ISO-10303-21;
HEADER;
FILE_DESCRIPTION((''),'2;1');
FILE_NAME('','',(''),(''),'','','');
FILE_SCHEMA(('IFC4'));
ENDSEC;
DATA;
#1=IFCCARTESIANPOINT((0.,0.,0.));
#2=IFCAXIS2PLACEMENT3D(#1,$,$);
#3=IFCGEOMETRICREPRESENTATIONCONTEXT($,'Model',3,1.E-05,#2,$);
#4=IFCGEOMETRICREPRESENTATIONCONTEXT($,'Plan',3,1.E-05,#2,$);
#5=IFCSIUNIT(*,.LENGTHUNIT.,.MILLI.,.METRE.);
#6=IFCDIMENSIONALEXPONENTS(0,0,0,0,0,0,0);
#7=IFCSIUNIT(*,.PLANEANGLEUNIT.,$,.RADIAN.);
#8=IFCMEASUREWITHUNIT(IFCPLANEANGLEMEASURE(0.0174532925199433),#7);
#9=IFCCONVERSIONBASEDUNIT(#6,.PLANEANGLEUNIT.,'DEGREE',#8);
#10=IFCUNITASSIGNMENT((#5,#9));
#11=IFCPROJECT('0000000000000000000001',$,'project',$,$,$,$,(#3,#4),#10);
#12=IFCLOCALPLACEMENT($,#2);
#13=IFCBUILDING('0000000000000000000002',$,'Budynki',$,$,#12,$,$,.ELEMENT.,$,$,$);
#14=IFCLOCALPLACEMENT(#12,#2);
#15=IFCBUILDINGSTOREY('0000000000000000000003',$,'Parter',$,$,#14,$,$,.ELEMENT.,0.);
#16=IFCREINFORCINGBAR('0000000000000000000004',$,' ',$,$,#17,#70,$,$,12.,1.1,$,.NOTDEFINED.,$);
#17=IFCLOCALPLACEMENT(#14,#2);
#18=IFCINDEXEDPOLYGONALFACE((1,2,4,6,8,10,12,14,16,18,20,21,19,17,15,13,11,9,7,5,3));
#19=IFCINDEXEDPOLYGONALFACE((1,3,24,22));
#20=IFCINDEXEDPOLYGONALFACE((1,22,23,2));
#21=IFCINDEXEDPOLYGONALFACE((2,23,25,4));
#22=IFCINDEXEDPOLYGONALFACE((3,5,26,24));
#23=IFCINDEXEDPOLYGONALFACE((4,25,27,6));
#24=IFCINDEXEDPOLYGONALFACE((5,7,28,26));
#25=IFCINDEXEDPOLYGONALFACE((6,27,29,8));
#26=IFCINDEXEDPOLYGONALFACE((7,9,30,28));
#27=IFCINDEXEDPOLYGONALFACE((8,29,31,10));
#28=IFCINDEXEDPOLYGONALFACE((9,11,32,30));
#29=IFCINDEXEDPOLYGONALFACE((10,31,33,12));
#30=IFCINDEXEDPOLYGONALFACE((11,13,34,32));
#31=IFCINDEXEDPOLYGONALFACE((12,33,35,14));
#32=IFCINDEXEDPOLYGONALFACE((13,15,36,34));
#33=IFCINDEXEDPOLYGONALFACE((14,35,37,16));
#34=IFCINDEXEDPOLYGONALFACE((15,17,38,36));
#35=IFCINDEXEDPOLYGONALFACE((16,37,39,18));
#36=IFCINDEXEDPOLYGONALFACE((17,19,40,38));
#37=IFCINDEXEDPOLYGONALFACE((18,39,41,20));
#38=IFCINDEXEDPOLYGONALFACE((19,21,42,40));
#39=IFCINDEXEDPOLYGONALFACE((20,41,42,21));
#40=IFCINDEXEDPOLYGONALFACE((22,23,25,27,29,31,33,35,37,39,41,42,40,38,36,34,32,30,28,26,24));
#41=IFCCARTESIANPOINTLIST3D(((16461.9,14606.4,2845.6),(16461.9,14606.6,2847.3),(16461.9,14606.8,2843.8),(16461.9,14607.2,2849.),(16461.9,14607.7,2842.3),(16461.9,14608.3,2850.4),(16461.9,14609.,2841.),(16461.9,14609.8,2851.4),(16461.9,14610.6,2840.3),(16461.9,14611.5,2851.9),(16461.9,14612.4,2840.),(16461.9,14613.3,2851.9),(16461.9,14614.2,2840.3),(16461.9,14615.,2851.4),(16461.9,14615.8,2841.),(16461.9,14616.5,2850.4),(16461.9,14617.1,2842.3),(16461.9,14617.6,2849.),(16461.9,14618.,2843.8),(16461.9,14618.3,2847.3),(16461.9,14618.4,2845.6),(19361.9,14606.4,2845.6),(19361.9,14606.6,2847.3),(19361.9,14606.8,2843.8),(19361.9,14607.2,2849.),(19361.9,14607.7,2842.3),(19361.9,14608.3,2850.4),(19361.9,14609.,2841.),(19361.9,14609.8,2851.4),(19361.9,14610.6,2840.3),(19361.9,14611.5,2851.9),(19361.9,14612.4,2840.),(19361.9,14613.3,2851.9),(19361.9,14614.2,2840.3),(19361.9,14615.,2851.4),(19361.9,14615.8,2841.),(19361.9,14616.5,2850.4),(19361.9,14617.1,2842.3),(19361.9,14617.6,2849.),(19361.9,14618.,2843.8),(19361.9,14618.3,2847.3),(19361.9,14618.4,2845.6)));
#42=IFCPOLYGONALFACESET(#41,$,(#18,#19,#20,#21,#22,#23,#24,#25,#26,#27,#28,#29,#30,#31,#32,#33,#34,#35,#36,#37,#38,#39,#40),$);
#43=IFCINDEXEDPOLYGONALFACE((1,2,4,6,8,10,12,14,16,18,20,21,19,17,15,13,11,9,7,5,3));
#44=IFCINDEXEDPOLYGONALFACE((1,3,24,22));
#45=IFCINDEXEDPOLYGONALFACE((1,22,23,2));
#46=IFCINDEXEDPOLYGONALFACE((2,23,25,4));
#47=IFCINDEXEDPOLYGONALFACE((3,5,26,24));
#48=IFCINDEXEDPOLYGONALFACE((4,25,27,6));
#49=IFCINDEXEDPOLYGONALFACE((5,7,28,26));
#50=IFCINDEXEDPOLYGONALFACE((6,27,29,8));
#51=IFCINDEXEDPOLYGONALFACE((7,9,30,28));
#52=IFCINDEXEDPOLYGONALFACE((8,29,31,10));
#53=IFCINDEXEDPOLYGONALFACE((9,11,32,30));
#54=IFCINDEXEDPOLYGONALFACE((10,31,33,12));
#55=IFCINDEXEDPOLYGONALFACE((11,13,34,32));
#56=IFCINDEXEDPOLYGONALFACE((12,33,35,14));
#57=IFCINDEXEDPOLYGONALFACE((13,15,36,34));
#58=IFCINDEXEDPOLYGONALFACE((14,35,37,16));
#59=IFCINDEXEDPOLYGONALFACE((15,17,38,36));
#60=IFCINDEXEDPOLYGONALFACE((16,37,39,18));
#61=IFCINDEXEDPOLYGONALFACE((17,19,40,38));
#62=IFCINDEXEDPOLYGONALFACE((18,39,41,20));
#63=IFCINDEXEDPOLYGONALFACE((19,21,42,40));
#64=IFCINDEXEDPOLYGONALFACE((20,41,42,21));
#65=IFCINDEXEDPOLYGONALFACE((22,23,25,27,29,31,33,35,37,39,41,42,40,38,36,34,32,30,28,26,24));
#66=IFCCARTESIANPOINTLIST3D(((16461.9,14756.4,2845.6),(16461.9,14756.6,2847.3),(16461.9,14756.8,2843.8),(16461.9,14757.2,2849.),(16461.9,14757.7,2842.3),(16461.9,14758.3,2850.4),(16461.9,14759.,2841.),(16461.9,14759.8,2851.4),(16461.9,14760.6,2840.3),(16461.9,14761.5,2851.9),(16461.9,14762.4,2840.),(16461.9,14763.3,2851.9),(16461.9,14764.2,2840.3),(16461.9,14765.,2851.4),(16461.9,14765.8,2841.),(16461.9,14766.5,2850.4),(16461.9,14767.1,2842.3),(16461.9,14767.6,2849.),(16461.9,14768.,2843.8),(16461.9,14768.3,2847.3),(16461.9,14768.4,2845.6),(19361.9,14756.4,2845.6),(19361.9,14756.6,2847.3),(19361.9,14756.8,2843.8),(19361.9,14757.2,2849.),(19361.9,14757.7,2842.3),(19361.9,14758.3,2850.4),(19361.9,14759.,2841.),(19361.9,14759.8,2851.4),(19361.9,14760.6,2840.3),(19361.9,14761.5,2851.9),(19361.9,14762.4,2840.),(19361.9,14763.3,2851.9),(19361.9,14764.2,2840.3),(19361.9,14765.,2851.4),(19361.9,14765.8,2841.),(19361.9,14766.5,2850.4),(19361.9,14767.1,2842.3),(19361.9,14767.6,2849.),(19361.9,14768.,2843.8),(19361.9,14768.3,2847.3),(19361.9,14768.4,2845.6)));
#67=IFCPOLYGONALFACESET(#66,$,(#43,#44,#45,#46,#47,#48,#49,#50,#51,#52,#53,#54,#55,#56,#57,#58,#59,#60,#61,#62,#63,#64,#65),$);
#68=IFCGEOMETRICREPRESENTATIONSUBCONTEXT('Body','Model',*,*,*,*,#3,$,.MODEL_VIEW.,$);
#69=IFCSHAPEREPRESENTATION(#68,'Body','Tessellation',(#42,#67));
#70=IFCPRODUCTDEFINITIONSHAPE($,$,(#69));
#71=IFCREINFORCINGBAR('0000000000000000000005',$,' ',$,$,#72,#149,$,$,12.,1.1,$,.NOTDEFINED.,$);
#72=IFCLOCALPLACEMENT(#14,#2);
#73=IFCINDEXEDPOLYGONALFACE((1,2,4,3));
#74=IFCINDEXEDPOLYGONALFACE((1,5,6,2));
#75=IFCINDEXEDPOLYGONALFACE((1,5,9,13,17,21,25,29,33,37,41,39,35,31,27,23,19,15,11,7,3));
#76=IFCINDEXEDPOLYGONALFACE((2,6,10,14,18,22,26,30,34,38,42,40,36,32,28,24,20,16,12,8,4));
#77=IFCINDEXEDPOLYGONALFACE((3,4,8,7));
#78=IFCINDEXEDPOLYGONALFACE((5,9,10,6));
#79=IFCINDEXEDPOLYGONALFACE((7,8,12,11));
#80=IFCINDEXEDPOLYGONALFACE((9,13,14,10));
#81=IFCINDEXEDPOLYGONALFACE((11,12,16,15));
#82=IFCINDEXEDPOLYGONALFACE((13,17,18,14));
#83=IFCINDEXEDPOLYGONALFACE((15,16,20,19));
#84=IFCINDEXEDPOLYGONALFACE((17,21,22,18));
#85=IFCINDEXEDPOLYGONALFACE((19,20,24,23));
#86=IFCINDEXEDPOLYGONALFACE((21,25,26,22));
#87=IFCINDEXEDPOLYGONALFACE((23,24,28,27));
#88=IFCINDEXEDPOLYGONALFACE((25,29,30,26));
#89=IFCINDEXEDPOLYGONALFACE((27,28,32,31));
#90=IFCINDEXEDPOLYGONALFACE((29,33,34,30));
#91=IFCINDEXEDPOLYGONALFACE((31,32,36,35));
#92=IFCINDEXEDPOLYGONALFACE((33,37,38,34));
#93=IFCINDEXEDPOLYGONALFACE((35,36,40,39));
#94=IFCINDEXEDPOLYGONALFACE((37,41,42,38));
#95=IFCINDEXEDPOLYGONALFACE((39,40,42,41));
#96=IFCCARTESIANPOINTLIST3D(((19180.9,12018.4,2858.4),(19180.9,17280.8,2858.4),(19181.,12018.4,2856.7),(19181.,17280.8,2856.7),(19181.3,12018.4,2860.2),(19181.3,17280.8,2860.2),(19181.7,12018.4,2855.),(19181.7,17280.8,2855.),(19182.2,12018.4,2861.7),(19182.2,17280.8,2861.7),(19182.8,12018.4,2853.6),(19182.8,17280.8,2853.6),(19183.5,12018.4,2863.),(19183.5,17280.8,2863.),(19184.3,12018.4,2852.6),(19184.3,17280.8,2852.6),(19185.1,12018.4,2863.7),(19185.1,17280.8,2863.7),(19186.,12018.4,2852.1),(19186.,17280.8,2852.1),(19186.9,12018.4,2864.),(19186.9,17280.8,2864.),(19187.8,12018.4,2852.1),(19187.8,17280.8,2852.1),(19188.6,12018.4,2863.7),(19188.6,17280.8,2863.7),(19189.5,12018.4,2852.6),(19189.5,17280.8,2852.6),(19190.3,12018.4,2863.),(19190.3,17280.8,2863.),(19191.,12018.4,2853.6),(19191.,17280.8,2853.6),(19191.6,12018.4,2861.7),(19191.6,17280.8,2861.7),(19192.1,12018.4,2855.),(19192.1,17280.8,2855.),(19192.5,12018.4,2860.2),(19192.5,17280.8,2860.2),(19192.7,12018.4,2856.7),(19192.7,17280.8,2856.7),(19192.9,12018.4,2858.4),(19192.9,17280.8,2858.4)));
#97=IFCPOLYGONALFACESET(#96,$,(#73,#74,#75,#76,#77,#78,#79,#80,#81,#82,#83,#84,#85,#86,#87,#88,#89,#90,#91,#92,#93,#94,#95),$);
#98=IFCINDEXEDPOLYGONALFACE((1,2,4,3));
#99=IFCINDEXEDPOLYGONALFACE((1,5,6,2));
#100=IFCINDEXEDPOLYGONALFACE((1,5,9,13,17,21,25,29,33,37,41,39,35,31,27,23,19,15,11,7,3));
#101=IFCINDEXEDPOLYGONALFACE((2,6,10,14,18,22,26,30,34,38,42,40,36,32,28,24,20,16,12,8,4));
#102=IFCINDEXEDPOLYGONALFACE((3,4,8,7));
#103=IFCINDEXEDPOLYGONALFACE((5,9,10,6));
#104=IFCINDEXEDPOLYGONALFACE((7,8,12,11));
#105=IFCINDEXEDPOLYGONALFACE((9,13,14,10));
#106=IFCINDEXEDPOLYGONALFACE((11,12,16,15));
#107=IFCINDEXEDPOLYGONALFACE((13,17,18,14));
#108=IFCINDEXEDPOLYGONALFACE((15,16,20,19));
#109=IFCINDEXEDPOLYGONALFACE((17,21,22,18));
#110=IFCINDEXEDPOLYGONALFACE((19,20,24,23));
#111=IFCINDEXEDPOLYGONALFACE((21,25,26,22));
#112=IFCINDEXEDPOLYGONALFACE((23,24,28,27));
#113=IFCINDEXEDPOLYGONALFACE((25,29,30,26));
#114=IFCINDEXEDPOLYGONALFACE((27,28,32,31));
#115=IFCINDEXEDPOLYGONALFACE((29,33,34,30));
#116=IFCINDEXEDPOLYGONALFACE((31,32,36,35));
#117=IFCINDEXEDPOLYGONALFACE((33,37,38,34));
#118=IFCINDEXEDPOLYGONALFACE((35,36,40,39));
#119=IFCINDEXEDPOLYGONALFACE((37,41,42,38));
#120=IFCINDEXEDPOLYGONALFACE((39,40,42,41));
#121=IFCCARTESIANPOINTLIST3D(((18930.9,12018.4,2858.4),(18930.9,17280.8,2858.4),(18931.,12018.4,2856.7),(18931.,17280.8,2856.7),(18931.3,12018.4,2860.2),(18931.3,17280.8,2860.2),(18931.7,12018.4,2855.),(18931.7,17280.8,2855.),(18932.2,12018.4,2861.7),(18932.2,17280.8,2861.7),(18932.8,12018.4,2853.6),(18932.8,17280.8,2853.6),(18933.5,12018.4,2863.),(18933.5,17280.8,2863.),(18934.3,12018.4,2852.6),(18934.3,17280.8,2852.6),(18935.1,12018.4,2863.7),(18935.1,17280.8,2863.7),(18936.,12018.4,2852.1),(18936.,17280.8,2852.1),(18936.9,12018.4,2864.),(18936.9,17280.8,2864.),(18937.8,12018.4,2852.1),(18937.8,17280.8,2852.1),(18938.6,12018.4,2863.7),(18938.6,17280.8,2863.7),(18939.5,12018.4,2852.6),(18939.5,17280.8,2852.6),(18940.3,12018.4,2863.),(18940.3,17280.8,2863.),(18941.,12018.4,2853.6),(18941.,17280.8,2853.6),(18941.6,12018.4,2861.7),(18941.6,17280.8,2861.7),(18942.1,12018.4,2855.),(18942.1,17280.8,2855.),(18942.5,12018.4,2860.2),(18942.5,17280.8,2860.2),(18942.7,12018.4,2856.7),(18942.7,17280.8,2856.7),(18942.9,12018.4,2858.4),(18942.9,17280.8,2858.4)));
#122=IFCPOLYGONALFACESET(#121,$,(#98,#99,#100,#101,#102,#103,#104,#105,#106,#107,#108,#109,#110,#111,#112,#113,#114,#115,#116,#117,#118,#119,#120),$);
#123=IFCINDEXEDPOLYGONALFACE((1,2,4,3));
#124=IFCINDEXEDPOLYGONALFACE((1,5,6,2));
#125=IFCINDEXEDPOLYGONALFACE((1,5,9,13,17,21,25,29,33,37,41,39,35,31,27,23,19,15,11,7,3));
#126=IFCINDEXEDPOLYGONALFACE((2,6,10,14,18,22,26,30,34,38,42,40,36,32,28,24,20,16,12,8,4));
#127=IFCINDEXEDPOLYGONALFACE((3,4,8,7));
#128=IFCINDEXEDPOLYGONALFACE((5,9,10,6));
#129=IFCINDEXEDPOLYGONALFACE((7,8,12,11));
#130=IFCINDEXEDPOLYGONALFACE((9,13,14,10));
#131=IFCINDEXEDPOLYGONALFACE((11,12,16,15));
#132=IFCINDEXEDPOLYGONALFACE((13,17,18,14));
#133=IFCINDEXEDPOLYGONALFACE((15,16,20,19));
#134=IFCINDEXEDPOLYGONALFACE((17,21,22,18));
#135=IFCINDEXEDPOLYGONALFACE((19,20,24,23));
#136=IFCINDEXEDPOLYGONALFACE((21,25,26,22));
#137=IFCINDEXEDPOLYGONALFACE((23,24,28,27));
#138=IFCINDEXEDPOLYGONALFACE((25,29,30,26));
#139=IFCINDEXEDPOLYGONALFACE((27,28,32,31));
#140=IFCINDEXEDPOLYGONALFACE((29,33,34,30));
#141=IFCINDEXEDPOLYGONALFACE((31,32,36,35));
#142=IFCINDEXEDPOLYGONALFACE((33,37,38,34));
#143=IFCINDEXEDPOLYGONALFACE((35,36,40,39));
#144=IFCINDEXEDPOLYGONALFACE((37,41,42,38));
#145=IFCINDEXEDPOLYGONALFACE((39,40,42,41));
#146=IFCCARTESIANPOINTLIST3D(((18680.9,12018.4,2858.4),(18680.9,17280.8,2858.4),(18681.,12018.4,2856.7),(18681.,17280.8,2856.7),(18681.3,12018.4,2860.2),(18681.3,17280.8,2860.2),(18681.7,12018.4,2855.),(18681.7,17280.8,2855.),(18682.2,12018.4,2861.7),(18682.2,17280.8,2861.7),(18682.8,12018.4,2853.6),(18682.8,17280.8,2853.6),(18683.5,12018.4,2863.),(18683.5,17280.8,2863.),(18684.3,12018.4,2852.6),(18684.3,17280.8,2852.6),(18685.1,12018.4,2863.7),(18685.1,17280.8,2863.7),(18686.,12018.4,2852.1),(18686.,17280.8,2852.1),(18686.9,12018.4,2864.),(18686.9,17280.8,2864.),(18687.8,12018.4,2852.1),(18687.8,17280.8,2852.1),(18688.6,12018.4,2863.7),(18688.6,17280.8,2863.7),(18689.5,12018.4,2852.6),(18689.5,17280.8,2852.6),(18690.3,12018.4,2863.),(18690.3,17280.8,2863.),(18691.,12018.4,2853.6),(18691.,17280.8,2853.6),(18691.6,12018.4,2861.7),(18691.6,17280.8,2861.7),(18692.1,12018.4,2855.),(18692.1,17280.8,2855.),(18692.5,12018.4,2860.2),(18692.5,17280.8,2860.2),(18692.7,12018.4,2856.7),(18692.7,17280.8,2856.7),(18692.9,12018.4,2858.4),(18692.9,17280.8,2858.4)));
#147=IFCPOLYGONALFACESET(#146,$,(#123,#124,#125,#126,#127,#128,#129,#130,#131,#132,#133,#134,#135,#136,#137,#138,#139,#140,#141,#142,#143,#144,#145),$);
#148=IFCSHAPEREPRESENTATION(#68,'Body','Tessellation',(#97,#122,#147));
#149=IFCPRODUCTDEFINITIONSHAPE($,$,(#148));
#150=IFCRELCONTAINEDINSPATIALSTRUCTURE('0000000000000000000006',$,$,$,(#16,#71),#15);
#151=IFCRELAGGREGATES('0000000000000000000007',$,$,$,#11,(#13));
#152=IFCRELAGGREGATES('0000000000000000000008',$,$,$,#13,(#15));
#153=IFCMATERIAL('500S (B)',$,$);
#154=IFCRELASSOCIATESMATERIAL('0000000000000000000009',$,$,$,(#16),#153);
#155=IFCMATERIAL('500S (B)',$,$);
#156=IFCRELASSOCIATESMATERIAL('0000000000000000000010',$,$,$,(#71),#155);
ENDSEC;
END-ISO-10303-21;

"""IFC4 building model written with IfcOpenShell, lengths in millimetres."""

from ifc_helpers import new_model, entity, si_unit, converted_unit, frame, origin, place, context, subcontext, project, spatial, material, element, save


model = new_model("IFC4")

# Units and contexts
model_context = context("Model", 3, precision=1e-05, world=origin())
plan_context = context("Plan", 3, precision=1e-05, world=origin())
body_context = subcontext(model_context, "Body", "Model", "MODEL_VIEW")
ifc_project = project(units=[si_unit("LENGTHUNIT", "METRE", prefix="MILLI"), converted_unit("PLANEANGLEUNIT", "DEGREE", entity("IfcPlaneAngleMeasure", 0.0174532925199433), si_unit("PLANEANGLEUNIT", "RADIAN"), dimensions=[0, 0, 0, 0, 0, 0, 0])], contexts=[model_context, plan_context])

# Building, storey
building_placement = place(None, origin())
building = spatial("IfcBuilding", under=ifc_project, at=building_placement, Name="Budynki", CompositionType="ELEMENT")
storey_placement = place(building_placement, origin())
storey = spatial("IfcBuildingStorey", under=building, at=storey_placement, Name="Parter", CompositionType="ELEMENT", Elevation=0.0)

# Reinforcing bars
ifc_material_1 = material(Name="500S (B)")
reinforcing_bar_1_placement = place(storey_placement, frame((19361.9, 14612.4, 2846.0)))
element("IfcReinforcingBar", 1, at=reinforcing_bar_1_placement, inside=storey, material=ifc_material_1, Name=" ", CrossSectionArea=1.1, NominalDiameter=12.0, PredefinedType="NOTDEFINED", context=body_context, shape_type="AdvancedSweptSolid", body=[
    entity("IfcSweptDiskSolid", entity("IfcPolyline", [entity("IfcCartesianPoint", [0.0, 0.0, 0.0]), entity("IfcCartesianPoint", [-2900.0, 0.0, 0.0])]), 6.0, None, 0.0, 1.0),
    entity("IfcSweptDiskSolid", entity("IfcPolyline", [entity("IfcCartesianPoint", [0.0, 150.0, 0.0]), entity("IfcCartesianPoint", [-2900.0, 150.0, 0.0])]), 6.0, None, 0.0, 1.0),
])
ifc_material_2 = material(Name="500S (B)")
reinforcing_bar_2_placement = place(storey_placement, frame((19186.9, 12018.4, 2858.0)))
element("IfcReinforcingBar", 2, at=reinforcing_bar_2_placement, inside=storey, material=ifc_material_2, Name=" ", CrossSectionArea=1.1, NominalDiameter=12.0, PredefinedType="NOTDEFINED", context=body_context, shape_type="AdvancedSweptSolid", body=[
    entity("IfcSweptDiskSolid", entity("IfcPolyline", [entity("IfcCartesianPoint", [0.0, 0.0, 0.0]), entity("IfcCartesianPoint", [0.0, 5262.4, 0.0])]), 6.0, None, 0.0, 1.0),
    entity("IfcSweptDiskSolid", entity("IfcPolyline", [entity("IfcCartesianPoint", [-250.0, 0.0, 0.0]), entity("IfcCartesianPoint", [-250.0, 5262.4, 0.0])]), 6.0, None, 0.0, 1.0),
    entity("IfcSweptDiskSolid", entity("IfcPolyline", [entity("IfcCartesianPoint", [-500.0, 0.0, 0.0]), entity("IfcCartesianPoint", [-500.0, 5262.4, 0.0])]), 6.0, None, 0.0, 1.0),
])

save(model, "model.ifc")
